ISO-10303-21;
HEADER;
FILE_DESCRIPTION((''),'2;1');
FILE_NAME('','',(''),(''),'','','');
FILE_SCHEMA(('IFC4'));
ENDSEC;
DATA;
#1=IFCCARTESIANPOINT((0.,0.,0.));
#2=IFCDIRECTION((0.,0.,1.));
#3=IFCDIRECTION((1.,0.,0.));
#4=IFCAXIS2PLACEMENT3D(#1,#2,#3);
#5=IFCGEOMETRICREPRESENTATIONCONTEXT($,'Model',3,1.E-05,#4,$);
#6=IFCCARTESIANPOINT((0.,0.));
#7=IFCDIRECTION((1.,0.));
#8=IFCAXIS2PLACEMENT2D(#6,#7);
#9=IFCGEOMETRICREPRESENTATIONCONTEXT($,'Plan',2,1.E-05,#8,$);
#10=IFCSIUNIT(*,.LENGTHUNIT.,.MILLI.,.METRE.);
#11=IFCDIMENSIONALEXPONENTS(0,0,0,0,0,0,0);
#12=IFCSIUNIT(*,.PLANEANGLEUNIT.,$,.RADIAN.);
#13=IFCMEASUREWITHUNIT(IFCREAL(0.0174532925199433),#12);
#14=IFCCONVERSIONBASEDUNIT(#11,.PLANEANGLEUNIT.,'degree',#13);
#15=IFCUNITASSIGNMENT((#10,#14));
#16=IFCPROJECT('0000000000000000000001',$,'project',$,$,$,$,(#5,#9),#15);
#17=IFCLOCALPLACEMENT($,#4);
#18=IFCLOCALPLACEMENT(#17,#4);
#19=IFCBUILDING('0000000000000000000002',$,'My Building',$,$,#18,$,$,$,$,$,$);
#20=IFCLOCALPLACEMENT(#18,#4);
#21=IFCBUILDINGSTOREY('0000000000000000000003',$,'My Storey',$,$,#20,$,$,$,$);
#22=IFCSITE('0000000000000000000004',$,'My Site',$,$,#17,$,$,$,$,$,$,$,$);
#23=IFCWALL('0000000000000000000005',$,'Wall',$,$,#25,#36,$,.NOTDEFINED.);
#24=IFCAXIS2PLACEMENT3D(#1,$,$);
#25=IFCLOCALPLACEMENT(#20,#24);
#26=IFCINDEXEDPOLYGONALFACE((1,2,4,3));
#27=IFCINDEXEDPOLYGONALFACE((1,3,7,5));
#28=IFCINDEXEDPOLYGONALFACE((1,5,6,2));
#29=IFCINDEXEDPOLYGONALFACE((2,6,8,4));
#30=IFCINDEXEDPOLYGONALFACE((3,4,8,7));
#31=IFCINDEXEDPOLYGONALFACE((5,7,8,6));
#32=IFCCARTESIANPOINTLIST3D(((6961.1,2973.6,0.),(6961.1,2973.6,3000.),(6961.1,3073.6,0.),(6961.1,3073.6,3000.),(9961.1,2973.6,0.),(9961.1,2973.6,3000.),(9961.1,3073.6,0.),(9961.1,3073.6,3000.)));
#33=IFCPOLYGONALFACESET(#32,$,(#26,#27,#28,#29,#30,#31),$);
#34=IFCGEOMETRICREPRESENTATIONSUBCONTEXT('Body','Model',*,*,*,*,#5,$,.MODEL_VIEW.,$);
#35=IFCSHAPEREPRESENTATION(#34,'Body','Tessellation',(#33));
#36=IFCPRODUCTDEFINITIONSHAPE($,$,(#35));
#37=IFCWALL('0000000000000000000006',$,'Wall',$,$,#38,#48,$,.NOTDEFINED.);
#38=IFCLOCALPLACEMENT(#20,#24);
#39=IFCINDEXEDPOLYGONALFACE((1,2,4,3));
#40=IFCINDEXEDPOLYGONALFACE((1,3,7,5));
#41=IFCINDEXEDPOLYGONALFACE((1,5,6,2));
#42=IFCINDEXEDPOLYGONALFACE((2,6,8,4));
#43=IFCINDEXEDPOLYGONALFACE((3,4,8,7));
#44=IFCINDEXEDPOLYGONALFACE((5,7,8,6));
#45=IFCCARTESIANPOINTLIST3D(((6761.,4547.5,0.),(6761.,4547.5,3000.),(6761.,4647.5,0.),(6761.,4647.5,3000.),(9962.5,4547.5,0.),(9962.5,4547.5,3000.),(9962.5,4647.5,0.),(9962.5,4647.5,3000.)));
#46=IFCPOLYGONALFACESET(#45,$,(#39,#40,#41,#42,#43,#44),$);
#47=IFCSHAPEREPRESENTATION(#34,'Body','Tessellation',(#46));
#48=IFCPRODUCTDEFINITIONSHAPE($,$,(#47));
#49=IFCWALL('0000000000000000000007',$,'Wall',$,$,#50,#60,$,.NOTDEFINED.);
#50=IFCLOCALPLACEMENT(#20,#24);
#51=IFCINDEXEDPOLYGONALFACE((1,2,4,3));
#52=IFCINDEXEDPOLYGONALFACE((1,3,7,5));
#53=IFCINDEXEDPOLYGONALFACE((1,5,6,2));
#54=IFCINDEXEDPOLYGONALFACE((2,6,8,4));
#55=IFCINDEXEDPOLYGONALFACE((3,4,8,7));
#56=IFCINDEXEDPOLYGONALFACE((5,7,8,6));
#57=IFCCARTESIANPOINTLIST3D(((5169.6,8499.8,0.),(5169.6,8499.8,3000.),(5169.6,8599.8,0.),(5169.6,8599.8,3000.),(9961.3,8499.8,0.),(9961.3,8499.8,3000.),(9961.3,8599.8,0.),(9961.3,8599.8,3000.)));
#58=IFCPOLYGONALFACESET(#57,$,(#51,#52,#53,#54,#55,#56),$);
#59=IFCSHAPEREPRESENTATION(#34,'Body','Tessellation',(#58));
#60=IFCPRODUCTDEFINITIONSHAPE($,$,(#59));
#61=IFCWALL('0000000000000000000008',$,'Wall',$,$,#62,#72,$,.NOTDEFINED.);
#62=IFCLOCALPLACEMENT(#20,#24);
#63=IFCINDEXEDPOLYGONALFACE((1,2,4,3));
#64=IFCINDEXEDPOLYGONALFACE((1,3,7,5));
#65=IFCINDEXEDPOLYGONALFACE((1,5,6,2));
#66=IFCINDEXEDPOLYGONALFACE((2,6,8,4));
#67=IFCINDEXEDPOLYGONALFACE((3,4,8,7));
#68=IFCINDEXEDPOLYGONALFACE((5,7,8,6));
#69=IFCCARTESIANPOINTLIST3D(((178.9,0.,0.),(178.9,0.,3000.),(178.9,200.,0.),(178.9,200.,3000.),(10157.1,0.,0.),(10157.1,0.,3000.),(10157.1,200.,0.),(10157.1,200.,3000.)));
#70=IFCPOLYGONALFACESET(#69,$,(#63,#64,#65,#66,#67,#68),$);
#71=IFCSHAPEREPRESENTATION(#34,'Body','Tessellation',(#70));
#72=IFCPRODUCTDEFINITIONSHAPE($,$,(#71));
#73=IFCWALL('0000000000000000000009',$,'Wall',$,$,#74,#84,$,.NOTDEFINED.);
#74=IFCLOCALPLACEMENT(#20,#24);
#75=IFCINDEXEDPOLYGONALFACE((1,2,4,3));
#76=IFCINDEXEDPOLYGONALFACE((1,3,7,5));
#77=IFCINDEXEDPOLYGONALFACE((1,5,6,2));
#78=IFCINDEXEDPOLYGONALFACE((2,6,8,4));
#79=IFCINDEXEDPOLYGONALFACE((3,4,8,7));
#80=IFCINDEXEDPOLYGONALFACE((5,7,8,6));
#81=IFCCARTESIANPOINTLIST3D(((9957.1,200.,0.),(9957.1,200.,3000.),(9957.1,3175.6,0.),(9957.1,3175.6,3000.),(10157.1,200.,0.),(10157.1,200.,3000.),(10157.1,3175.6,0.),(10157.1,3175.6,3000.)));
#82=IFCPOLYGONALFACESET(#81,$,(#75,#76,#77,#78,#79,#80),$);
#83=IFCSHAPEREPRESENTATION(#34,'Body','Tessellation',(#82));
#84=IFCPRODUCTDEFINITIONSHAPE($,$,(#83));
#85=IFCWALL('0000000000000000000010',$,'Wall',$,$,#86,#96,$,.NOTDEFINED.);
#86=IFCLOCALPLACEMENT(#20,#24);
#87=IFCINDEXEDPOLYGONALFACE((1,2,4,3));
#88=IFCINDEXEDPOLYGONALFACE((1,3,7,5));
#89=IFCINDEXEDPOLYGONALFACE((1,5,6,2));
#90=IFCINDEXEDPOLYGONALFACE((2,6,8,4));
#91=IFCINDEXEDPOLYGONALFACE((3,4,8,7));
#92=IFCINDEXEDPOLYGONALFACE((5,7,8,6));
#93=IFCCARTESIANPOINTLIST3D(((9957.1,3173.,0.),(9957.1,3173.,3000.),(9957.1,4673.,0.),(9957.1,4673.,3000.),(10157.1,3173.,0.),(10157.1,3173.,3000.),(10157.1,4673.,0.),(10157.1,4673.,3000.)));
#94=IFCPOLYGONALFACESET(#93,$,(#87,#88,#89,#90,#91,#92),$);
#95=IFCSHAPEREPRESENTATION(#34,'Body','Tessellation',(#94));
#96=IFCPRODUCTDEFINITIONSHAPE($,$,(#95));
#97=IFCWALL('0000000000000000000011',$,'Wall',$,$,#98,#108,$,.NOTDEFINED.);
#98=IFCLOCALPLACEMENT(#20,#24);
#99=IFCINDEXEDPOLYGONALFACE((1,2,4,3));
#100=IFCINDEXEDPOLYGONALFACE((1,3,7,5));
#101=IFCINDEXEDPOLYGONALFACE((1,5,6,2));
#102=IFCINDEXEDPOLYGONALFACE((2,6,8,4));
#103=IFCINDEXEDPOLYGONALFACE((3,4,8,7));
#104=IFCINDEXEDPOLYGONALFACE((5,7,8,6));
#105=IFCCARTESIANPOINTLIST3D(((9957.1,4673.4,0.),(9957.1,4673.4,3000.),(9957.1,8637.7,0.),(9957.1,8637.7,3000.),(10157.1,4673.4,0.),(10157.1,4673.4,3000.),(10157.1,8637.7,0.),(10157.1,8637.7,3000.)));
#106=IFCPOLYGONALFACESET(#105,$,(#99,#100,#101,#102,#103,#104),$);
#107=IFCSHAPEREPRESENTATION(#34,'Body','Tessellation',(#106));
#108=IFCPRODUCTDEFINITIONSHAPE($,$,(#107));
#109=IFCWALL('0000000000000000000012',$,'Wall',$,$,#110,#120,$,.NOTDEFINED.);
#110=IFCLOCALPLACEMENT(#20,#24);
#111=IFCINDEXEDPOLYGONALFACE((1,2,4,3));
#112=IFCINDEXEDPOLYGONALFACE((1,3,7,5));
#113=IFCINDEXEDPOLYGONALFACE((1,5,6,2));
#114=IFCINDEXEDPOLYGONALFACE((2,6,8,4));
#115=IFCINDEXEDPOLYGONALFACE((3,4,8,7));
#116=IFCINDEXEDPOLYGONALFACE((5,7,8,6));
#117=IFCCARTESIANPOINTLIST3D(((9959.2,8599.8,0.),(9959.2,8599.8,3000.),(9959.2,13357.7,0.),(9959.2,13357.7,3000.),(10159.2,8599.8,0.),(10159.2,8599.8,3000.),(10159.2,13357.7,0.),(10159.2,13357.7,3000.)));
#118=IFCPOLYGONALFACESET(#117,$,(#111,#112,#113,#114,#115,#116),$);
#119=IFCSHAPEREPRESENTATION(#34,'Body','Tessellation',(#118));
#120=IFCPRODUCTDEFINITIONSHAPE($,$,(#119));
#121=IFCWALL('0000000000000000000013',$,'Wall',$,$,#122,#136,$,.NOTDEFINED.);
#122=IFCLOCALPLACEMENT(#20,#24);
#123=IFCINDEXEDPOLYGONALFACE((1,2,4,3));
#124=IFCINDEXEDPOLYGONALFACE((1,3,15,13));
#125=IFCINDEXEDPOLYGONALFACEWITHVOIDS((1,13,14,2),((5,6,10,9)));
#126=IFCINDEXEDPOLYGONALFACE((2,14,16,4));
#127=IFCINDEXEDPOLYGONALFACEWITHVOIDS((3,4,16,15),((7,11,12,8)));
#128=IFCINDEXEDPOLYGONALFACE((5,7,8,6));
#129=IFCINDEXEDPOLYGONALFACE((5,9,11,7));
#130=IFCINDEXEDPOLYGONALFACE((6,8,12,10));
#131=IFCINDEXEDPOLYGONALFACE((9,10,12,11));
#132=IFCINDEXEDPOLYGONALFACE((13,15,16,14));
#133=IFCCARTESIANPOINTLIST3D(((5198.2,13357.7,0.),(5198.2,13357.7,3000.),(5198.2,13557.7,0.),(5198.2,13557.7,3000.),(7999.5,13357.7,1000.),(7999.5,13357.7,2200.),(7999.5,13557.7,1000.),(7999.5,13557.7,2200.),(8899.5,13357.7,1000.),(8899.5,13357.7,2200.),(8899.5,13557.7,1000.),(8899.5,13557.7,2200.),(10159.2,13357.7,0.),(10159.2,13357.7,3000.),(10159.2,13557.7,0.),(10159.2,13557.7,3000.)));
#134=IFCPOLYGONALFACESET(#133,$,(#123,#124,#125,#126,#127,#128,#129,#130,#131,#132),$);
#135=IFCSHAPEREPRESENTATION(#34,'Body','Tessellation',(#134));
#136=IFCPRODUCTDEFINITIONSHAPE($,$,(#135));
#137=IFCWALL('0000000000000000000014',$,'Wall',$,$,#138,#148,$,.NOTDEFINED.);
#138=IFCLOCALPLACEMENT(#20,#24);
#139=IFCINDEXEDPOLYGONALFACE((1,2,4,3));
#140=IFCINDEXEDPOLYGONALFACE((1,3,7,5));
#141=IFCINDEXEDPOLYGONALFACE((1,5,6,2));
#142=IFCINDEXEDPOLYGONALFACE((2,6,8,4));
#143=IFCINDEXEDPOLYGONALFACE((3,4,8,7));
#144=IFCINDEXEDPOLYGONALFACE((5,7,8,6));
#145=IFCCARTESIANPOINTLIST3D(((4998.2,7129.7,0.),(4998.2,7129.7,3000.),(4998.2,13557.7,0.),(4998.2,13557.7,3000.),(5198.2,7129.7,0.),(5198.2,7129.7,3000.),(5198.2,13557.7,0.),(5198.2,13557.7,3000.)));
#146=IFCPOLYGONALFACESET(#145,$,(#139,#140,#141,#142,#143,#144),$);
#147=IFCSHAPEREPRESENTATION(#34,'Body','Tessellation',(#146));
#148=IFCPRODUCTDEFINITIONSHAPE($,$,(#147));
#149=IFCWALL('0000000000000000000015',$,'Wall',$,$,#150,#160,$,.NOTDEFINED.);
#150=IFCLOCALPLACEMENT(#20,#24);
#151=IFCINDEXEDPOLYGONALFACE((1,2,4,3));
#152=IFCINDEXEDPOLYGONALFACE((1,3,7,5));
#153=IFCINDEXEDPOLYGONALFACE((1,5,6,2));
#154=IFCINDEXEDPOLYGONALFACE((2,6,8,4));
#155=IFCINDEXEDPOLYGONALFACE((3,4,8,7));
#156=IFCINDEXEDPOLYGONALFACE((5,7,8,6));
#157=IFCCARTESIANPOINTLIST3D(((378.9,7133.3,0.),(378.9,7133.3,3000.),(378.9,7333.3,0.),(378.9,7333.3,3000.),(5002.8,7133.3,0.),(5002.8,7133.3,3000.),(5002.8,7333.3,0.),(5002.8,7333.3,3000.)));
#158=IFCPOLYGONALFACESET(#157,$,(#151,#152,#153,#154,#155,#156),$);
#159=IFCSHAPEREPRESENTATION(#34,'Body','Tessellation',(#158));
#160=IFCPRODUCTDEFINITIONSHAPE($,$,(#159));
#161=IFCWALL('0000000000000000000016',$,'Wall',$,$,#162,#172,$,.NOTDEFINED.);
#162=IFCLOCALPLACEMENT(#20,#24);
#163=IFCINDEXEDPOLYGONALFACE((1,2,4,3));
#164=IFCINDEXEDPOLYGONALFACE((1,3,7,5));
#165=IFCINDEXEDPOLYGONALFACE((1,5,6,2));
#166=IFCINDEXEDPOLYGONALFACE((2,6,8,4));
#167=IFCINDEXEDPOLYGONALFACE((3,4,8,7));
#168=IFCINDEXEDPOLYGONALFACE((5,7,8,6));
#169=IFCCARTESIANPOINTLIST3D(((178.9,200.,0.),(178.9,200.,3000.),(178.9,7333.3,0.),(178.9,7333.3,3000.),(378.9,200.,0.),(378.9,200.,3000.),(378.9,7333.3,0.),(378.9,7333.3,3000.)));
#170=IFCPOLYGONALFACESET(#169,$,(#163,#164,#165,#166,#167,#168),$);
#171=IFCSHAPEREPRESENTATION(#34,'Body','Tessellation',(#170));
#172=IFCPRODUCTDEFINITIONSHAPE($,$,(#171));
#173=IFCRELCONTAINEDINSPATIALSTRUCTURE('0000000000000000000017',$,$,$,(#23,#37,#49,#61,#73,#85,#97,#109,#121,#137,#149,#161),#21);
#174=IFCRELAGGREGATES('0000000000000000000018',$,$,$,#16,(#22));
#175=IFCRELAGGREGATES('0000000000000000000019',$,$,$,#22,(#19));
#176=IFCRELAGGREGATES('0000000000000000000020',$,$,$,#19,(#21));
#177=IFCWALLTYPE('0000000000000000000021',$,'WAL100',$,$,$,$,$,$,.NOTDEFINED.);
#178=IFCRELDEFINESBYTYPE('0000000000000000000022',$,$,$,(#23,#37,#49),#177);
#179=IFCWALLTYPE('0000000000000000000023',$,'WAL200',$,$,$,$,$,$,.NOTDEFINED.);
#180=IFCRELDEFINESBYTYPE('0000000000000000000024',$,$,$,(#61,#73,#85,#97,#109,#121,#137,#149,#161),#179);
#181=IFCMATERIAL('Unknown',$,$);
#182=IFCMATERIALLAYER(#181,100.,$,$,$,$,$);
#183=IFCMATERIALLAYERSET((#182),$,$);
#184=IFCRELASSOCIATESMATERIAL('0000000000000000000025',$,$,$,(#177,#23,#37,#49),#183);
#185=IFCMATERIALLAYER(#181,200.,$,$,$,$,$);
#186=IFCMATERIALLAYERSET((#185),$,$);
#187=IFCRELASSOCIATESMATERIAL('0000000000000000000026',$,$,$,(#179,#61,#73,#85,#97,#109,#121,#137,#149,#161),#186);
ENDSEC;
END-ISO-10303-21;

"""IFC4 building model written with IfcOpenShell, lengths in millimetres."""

from ifc_helpers import new_model, entity, si_unit, converted_unit, frame, origin_with_axes, origin_2d_with_axis, place, context, subcontext, project, spatial, line, indexed_curve, outline, extrude, source, transform, mapped, material, layer, layer_set, layer_usage, type_object, element, save


model = new_model("IFC4")

# Units and contexts
model_context = context("Model", 3, precision=1e-05, world=origin_with_axes())
plan_context = context("Plan", 2, precision=1e-05, world=origin_2d_with_axis())
body_context = subcontext(model_context, "Body", "Model", "MODEL_VIEW")
ifc_project = project(units=[si_unit("LENGTHUNIT", "METRE", prefix="MILLI"), converted_unit("PLANEANGLEUNIT", "degree", entity("IfcReal", 0.0174532925199433), si_unit("PLANEANGLEUNIT", "RADIAN"), dimensions=[0, 0, 0, 0, 0, 0, 0])], contexts=[model_context, plan_context])

# Site, building, storey
site_placement = place(None, origin_with_axes())
site = spatial("IfcSite", under=ifc_project, at=site_placement, Name="My Site")
building_placement = place(site_placement, origin_with_axes())
building = spatial("IfcBuilding", under=site, at=building_placement, Name="My Building")
storey_placement = place(building_placement, origin_with_axes())
storey = spatial("IfcBuildingStorey", under=building, at=storey_placement, Name="My Storey")

# Walls
ifc_material = material(Name="Unknown")
ifc_layer_1 = layer(ifc_material, 100.0)
ifc_layer_set_1 = layer_set([ifc_layer_1])
ifc_layer_usage_1 = layer_usage(ifc_layer_set_1, "AXIS2", "POSITIVE", 0.0)
wall_type_1 = type_object("IfcWallType", Name="WAL100", PredefinedType="NOTDEFINED", material=ifc_layer_set_1)
wall_1_placement = place(storey_placement, frame((9961.1, 3073.6, 0.0), z_axis=(0.0, 0.0, 1.0), x_axis=(-1.0, 0.0, 0.0)))
element("IfcWall", 1, at=wall_1_placement, inside=storey, type_object=wall_type_1, material=ifc_layer_usage_1, Name="Wall", PredefinedType="NOTDEFINED", context=body_context, shape_type="SweptSolid", body=[
    extrude(outline(indexed_curve([(0.0, 0.0), (0.0, 100.0), (3000.0, 100.0), (3000.0, 0.0), (0.0, 0.0)], self_intersect=False)), origin_with_axes(), (0.0, 0.0, 1.0), 3000.0),
])
ifc_layer_usage_2 = layer_usage(ifc_layer_set_1, "AXIS2", "POSITIVE", 0.0)
wall_2_placement = place(storey_placement, frame((6761.0, 4547.5, 0.0), z_axis=(0.0, 0.0, 1.0), x_axis=(1.0, 0.0, 0.0)))
element("IfcWall", 2, at=wall_2_placement, inside=storey, type_object=wall_type_1, material=ifc_layer_usage_2, Name="Wall", PredefinedType="NOTDEFINED", context=body_context, shape_type="SweptSolid", body=[
    extrude(outline(indexed_curve([(0.0, 0.0), (0.0, 100.0), (3201.5, 100.0), (3201.5, 0.0), (0.0, 0.0)], self_intersect=False)), origin_with_axes(), (0.0, 0.0, 1.0), 3000.0),
])
ifc_layer_usage_3 = layer_usage(ifc_layer_set_1, "AXIS2", "POSITIVE", 0.0)
wall_3_placement = place(storey_placement, frame((9961.3, 8599.8, 0.0), z_axis=(0.0, 0.0, 1.0), x_axis=(-1.0, 0.000001, 0.0)))
element("IfcWall", 3, at=wall_3_placement, inside=storey, type_object=wall_type_1, material=ifc_layer_usage_3, Name="Wall", PredefinedType="NOTDEFINED", context=body_context, shape_type="SweptSolid", body=[
    extrude(outline(indexed_curve([(0.0, 0.0), (0.0, 100.0), (4791.8, 100.0), (4791.8, 0.0), (0.0, 0.0)], self_intersect=False)), origin_with_axes(), (0.0, 0.0, 1.0), 3000.0),
])
ifc_layer_2 = layer(ifc_material, 200.0)
ifc_layer_set_2 = layer_set([ifc_layer_2])
ifc_layer_usage_4 = layer_usage(ifc_layer_set_2, "AXIS2", "POSITIVE", 0.0)
wall_type_2 = type_object("IfcWallType", Name="WAL200", PredefinedType="NOTDEFINED", material=ifc_layer_set_2)
wall_4_placement = place(storey_placement, frame((178.9, 0.0, 0.0), z_axis=(0.0, 0.0, 1.0), x_axis=(1.0, 0.0, 0.0)))
element("IfcWall", 4, at=wall_4_placement, inside=storey, type_object=wall_type_2, material=ifc_layer_usage_4, Name="Wall", PredefinedType="NOTDEFINED", context=body_context, shape_type="SweptSolid", body=[
    extrude(outline(indexed_curve([(0.0, 0.0), (0.0, 200.0), (9978.2, 200.0), (9978.2, 0.0), (0.0, 0.0)], self_intersect=False)), origin_with_axes(), (0.0, 0.0, 1.0), 3000.0),
])
ifc_layer_usage_5 = layer_usage(ifc_layer_set_2, "AXIS2", "POSITIVE", 0.0)
wall_5_placement = place(storey_placement, frame((10157.1, 200.0, 0.0), z_axis=(0.0, 0.0, 1.0), x_axis=(0.0, 1.0, 0.0)))
element("IfcWall", 5, at=wall_5_placement, inside=storey, type_object=wall_type_2, material=ifc_layer_usage_5, Name="Wall", PredefinedType="NOTDEFINED", context=body_context, shape_type="SweptSolid", body=[
    extrude(outline(indexed_curve([(0.0, 0.0), (0.0, 200.0), (2975.6, 200.0), (2975.6, 0.0), (0.0, 0.0)], self_intersect=False)), origin_with_axes(), (0.0, 0.0, 1.0), 3000.0),
])
ifc_layer_usage_6 = layer_usage(ifc_layer_set_2, "AXIS2", "POSITIVE", 0.0)
wall_6_placement = place(storey_placement, frame((10157.1, 3173.0, 0.0), z_axis=(0.0, 0.0, 1.0), x_axis=(0.000001, 1.0, 0.0)))
element("IfcWall", 6, at=wall_6_placement, inside=storey, type_object=wall_type_2, material=ifc_layer_usage_6, Name="Wall", PredefinedType="NOTDEFINED", context=body_context, shape_type="SweptSolid", body=[
    extrude(outline(indexed_curve([(0.0, 0.0), (0.0, 200.0), (1500.0, 200.0), (1500.0, 0.0), (0.0, 0.0)], self_intersect=False)), origin_with_axes(), (0.0, 0.0, 1.0), 3000.0),
])
ifc_layer_usage_7 = layer_usage(ifc_layer_set_2, "AXIS2", "POSITIVE", 0.0)
wall_7_placement = place(storey_placement, frame((10157.1, 4673.4, 0.0), z_axis=(0.0, 0.0, 1.0), x_axis=(0.000002, 1.0, 0.0)))
element("IfcWall", 7, at=wall_7_placement, inside=storey, type_object=wall_type_2, material=ifc_layer_usage_7, Name="Wall", PredefinedType="NOTDEFINED", context=body_context, shape_type="SweptSolid", body=[
    extrude(outline(indexed_curve([(0.0, 0.0), (0.0, 200.0), (3964.3, 200.0), (3964.3, 0.0), (0.0, 0.0)], self_intersect=False)), origin_with_axes(), (0.0, 0.0, 1.0), 3000.0),
])
ifc_layer_usage_8 = layer_usage(ifc_layer_set_2, "AXIS2", "POSITIVE", 0.0)
wall_8_placement = place(storey_placement, frame((10159.2, 8599.8, 0.0), z_axis=(0.0, 0.0, 1.0), x_axis=(0.000002, 1.0, 0.0)))
element("IfcWall", 8, at=wall_8_placement, inside=storey, type_object=wall_type_2, material=ifc_layer_usage_8, Name="Wall", PredefinedType="NOTDEFINED", context=body_context, shape_type="SweptSolid", body=[
    extrude(outline(indexed_curve([(0.0, 0.0), (0.0, 200.0), (4757.9, 200.0), (4757.9, 0.0), (0.0, 0.0)], self_intersect=False)), origin_with_axes(), (0.0, 0.0, 1.0), 3000.0),
])

# Wall, opening
ifc_layer_usage_9 = layer_usage(ifc_layer_set_2, "AXIS2", "POSITIVE", 0.0)
wall_9_placement = place(storey_placement, frame((10159.2, 13557.7, 0.0), z_axis=(0.0, 0.0, 1.0), x_axis=(-1.0, 0.0, 0.0)))
wall_9 = element("IfcWall", 9, at=wall_9_placement, inside=storey, type_object=wall_type_2, material=ifc_layer_usage_9, Name="Wall", PredefinedType="NOTDEFINED", context=body_context, shape_type="SweptSolid", body=[
    extrude(outline(indexed_curve([(0.0, 0.0), (0.0, 200.0), (4961.0, 200.0), (4961.0, 0.0), (0.0, 0.0)], self_intersect=False)), origin_with_axes(), (0.0, 0.0, 1.0), 3000.0),
])
shared_shape = source(origin_with_axes(), body_context, "Body", "SweptSolid", [
    extrude(outline(indexed_curve([(0.0, 0.0, 0.0), (900.0, 0.0, 0.0), (900.0, 0.0, 1200.0), (0.0, 0.0, 1200.0)], segments=[line(1, 2), line(2, 3), line(3, 4), line(4, 1)])), frame((0.0, -100.0, 0.0), z_axis=(0.0, 0.0, 1.0), x_axis=(1.0, 0.0, 0.0)), (0.0, 1.0, 0.0), 400.0),
])
opening_placement = place(wall_9_placement, frame((1259.7, 0.0, 1000.0), z_axis=(0.0, 0.0, 1.0), x_axis=(1.0, 0.0, 0.0)))
element("IfcOpeningElement", 10, at=opening_placement, cuts=wall_9, PredefinedType="OPENING", context=body_context, shape_type="MappedRepresentation", body=[
    mapped(shared_shape, transform((0.0, 0.0, 0.0), x_axis=(1.0, 0.0, 0.0), y_axis=(0.0, 1.0, 0.0), z_axis=(0.0, 0.0, 1.0), scale=1.0)),
])

# Walls
ifc_layer_usage_10 = layer_usage(ifc_layer_set_2, "AXIS2", "POSITIVE", 0.0)
wall_10_placement = place(storey_placement, frame((4998.2, 13557.7, 0.0), z_axis=(0.0, 0.0, 1.0), x_axis=(0.0, -1.0, 0.0)))
element("IfcWall", 11, at=wall_10_placement, inside=storey, type_object=wall_type_2, material=ifc_layer_usage_10, Name="Wall", PredefinedType="NOTDEFINED", context=body_context, shape_type="SweptSolid", body=[
    extrude(outline(indexed_curve([(0.0, 0.0), (0.0, 200.0), (6428.1, 200.0), (6428.1, 0.0), (0.0, 0.0)], self_intersect=False)), origin_with_axes(), (0.0, 0.0, 1.0), 3000.0),
])
ifc_layer_usage_11 = layer_usage(ifc_layer_set_2, "AXIS2", "POSITIVE", 0.0)
wall_11_placement = place(storey_placement, frame((378.9, 7133.3, 0.0), z_axis=(0.0, 0.0, 1.0), x_axis=(1.0, -0.000001, 0.0)))
element("IfcWall", 12, at=wall_11_placement, inside=storey, type_object=wall_type_2, material=ifc_layer_usage_11, Name="Wall", PredefinedType="NOTDEFINED", context=body_context, shape_type="SweptSolid", body=[
    extrude(outline(indexed_curve([(0.0, 0.0), (0.0, 200.0), (4623.8, 200.0), (4623.8, 0.0), (0.0, 0.0)], self_intersect=False)), origin_with_axes(), (0.0, 0.0, 1.0), 3000.0),
])
ifc_layer_usage_12 = layer_usage(ifc_layer_set_2, "AXIS2", "POSITIVE", 0.0)
wall_12_placement = place(storey_placement, frame((178.9, 7333.3, 0.0), z_axis=(0.0, 0.0, 1.0), x_axis=(0.0, -1.0, 0.0)))
element("IfcWall", 13, at=wall_12_placement, inside=storey, type_object=wall_type_2, material=ifc_layer_usage_12, Name="Wall", PredefinedType="NOTDEFINED", context=body_context, shape_type="SweptSolid", body=[
    extrude(outline(indexed_curve([(0.0, 0.0), (0.0, 200.0), (7133.3, 200.0), (7133.3, 0.0), (0.0, 0.0)], self_intersect=False)), origin_with_axes(), (0.0, 0.0, 1.0), 3000.0),
])

save(model, "model.ifc")
